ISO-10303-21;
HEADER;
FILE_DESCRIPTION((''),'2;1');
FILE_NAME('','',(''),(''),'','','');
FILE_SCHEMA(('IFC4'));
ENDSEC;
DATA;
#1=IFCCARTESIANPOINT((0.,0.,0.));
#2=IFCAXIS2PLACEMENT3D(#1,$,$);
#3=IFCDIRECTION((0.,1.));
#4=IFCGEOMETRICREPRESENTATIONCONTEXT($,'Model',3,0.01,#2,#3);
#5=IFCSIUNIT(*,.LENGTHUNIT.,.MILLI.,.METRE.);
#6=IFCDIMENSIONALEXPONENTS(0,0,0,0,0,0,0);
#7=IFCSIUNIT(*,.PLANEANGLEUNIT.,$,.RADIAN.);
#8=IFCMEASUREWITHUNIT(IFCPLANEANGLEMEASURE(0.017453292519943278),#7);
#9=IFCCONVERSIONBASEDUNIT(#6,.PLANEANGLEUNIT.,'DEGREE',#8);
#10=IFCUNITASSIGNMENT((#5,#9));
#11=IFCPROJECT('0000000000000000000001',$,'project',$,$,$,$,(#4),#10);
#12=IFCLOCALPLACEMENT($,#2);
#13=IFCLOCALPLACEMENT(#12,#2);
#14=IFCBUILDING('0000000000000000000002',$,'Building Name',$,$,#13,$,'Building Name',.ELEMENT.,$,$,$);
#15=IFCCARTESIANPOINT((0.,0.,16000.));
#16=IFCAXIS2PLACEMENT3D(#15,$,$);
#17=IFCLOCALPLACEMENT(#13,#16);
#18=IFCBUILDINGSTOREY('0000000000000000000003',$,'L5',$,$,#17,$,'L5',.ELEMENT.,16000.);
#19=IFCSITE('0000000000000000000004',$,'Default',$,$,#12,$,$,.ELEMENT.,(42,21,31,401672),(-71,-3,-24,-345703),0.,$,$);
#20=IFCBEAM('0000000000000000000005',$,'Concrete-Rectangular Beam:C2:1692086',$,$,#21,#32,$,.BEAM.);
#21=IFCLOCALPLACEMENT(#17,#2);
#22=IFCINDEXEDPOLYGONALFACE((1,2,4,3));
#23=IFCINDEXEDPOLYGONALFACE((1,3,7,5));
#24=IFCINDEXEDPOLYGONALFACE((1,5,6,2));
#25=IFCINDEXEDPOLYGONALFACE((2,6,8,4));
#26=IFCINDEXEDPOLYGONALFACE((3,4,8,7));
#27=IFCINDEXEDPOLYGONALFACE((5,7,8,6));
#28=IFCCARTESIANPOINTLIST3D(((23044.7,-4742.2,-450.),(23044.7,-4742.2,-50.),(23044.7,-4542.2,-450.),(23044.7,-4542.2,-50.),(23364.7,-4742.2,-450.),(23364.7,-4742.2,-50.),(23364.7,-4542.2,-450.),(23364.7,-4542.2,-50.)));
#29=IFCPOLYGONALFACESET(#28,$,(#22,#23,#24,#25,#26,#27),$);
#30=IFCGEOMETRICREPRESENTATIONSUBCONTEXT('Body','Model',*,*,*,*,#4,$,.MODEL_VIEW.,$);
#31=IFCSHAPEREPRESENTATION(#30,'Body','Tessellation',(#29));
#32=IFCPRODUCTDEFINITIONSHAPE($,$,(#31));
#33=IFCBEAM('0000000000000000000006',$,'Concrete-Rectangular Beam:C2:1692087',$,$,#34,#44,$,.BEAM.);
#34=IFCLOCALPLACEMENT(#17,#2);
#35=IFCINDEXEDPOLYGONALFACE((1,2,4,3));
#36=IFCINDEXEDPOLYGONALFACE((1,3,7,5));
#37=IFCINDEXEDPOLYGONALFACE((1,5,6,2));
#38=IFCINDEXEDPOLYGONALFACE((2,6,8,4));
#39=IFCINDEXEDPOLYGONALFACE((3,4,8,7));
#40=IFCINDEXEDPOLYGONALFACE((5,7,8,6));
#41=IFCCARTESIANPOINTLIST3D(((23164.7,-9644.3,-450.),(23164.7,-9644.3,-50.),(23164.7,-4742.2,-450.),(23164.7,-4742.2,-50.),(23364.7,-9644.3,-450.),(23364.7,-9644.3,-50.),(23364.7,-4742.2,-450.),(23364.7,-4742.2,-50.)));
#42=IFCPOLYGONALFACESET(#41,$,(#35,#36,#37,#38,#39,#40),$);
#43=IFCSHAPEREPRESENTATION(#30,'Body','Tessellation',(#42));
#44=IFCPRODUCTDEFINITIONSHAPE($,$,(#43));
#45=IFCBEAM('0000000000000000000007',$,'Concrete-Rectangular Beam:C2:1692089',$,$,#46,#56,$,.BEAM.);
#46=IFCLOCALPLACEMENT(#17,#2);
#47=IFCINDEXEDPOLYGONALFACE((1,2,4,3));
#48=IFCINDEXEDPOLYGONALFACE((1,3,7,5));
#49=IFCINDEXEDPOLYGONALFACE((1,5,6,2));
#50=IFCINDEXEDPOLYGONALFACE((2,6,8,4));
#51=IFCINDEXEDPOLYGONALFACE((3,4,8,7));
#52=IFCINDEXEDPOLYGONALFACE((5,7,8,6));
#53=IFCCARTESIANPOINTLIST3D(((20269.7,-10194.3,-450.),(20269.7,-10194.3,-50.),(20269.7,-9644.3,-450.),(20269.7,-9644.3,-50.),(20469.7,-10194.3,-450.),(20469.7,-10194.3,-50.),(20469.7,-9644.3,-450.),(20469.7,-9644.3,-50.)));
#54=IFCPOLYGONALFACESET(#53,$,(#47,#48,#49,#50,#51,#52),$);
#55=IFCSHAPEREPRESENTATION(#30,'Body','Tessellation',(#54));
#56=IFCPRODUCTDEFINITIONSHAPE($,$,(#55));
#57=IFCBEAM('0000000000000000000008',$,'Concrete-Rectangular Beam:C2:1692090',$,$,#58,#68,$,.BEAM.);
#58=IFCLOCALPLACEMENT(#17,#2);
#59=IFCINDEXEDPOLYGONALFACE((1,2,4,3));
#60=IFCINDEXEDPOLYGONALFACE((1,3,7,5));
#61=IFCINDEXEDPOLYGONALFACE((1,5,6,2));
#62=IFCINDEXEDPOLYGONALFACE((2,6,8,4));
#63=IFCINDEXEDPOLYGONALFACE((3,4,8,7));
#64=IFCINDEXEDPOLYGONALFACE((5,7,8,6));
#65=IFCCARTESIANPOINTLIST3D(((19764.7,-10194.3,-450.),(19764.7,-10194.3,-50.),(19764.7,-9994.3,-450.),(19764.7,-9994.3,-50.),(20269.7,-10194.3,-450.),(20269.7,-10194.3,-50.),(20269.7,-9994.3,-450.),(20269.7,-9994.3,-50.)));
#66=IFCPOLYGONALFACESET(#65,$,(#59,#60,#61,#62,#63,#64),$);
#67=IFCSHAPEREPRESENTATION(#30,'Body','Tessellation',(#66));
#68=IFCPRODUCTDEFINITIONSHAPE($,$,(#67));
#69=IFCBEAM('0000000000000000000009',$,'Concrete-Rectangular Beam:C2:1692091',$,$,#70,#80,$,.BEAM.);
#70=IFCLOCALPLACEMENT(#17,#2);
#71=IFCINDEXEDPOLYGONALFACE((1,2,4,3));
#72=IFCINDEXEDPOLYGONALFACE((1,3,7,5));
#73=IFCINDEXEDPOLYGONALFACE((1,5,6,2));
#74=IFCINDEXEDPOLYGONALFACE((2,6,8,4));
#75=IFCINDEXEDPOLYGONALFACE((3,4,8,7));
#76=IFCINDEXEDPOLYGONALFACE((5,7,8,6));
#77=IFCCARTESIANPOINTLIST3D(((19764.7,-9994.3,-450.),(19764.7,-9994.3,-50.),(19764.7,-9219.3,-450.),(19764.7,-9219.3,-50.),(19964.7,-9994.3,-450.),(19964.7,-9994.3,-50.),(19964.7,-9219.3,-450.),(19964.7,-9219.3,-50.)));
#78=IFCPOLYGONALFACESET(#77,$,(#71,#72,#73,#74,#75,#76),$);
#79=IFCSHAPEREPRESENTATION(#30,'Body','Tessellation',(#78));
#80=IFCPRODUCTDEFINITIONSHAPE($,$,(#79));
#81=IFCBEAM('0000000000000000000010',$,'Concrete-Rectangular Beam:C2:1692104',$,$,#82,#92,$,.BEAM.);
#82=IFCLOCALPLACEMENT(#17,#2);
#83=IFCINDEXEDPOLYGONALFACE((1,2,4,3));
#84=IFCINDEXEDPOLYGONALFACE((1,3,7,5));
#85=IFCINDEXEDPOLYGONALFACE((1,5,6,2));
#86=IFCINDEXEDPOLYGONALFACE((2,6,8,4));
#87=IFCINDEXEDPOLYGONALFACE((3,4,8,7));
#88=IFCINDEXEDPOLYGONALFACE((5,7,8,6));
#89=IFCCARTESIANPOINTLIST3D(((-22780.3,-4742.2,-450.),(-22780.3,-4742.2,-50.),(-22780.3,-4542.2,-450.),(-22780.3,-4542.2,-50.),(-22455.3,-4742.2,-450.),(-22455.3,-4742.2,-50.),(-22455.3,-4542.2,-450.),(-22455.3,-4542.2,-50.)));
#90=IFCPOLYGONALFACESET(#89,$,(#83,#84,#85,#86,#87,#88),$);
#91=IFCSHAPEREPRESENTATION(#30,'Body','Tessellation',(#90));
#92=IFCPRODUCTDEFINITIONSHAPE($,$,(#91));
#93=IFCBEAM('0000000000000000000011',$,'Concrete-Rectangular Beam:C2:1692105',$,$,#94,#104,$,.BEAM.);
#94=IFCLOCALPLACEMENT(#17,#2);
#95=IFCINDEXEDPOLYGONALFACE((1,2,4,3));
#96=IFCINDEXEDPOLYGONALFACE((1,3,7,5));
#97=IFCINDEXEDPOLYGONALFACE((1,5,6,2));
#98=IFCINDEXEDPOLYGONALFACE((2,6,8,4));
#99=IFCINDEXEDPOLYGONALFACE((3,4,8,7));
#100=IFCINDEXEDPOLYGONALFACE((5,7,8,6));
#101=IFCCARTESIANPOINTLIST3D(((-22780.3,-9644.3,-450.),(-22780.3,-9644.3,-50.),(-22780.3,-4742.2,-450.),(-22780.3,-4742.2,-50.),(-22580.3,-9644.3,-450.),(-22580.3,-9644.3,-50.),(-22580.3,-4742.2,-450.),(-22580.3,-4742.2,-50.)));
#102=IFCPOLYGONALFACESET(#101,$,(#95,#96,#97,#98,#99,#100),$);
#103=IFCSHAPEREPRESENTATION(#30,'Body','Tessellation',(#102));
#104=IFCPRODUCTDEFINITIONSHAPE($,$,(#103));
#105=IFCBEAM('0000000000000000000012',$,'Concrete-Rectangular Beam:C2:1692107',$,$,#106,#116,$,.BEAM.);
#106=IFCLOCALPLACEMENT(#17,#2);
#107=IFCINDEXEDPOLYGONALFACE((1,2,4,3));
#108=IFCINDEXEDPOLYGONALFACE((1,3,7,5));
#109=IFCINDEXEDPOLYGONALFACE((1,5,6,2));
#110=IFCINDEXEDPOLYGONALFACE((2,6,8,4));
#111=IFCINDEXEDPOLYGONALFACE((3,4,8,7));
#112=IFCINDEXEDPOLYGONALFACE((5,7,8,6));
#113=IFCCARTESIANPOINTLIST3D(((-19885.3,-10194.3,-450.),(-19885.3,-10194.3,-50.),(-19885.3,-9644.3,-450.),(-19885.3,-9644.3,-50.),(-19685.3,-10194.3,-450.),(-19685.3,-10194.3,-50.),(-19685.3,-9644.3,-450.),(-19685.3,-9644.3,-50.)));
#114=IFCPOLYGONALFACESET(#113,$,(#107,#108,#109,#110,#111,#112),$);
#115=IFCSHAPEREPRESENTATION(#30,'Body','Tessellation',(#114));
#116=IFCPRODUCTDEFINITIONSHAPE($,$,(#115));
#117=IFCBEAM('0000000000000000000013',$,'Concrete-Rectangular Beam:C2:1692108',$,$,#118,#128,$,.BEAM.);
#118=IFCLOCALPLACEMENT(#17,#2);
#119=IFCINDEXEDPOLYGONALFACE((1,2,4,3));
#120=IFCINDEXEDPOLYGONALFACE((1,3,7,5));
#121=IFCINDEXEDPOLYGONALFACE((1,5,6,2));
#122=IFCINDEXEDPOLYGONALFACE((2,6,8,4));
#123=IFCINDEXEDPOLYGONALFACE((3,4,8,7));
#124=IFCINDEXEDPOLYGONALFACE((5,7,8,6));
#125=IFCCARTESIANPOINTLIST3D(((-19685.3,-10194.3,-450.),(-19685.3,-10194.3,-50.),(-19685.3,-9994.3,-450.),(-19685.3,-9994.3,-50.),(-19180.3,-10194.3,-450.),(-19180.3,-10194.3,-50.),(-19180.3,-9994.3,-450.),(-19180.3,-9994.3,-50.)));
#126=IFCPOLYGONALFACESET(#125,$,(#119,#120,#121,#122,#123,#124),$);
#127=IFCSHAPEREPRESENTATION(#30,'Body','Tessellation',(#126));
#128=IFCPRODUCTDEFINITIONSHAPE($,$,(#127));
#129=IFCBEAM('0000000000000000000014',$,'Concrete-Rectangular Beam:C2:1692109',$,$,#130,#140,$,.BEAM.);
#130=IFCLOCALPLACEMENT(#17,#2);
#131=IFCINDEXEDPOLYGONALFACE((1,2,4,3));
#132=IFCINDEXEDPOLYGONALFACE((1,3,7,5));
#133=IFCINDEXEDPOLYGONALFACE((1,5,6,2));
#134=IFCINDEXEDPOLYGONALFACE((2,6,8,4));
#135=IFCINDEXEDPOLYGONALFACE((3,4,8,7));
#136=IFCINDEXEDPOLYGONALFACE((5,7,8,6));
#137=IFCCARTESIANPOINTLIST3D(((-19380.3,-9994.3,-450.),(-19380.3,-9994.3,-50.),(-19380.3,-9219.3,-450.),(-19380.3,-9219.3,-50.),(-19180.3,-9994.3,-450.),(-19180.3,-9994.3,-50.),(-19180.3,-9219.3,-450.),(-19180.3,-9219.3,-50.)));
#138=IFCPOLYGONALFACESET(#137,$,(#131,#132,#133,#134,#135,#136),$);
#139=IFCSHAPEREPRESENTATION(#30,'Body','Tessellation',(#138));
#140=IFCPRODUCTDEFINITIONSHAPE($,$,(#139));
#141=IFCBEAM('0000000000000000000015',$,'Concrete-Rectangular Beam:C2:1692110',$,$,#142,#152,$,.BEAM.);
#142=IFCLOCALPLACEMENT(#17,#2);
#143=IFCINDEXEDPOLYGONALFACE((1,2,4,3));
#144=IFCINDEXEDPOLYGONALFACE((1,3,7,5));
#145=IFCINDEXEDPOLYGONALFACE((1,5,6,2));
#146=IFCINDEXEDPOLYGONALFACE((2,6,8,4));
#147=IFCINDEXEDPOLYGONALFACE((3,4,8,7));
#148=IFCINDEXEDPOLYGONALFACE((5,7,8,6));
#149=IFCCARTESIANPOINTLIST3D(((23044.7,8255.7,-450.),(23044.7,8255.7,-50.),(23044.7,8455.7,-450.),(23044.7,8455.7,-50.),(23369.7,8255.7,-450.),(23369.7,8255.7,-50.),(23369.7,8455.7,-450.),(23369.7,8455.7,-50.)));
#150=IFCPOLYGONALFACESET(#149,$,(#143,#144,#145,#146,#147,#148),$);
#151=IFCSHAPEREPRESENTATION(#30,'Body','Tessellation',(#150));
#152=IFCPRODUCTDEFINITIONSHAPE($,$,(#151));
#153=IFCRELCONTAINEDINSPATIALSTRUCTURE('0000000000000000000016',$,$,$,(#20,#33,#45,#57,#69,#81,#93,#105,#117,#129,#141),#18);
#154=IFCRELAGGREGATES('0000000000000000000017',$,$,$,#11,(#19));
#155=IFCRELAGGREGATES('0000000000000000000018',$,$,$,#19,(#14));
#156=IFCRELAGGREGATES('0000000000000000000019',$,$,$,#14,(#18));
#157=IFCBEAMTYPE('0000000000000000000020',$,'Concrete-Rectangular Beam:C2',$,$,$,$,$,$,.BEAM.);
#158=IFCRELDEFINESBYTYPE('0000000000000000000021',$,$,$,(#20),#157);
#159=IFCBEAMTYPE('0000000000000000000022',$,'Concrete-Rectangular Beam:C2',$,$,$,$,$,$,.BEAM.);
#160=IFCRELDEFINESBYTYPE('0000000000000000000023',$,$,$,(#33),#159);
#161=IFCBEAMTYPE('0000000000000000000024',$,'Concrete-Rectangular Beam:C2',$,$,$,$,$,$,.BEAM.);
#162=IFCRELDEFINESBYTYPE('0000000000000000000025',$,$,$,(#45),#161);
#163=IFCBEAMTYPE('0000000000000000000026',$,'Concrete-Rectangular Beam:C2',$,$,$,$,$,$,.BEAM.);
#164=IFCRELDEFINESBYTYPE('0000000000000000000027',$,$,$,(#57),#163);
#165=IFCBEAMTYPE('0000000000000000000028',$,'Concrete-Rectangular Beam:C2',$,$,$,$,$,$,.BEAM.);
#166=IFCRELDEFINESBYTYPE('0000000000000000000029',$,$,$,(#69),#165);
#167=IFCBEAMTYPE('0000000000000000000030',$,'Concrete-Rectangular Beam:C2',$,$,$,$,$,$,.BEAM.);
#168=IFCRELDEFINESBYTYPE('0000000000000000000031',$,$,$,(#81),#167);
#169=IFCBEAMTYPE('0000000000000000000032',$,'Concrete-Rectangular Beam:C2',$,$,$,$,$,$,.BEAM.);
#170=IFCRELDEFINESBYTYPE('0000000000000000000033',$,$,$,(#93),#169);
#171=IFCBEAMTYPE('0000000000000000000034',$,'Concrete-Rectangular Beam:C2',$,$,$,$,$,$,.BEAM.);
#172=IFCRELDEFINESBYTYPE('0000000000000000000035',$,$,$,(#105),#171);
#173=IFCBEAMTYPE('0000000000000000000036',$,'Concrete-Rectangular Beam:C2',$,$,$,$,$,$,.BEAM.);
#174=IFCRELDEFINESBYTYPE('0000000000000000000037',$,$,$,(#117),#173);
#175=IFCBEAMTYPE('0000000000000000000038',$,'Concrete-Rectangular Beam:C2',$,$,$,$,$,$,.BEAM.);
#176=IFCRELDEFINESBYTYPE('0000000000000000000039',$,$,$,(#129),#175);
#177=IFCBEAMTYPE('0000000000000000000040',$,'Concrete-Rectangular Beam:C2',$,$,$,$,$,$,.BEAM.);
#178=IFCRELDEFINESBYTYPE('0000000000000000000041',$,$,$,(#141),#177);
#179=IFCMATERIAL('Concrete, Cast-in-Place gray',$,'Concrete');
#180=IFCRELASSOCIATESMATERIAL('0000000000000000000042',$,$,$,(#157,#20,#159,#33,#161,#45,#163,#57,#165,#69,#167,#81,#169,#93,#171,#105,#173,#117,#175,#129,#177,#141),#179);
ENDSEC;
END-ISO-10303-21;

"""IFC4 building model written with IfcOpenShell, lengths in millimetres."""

from ifc_helpers import new_model, entity, si_unit, converted_unit, direction, frame, origin, place, context, subcontext, project, spatial, indexed_curve, outline, extrude, source, transform, mapped, material, type_object, type_shapes, element, save


model = new_model("IFC4")

# Units and contexts
model_context = context("Model", 3, precision=0.01, world=origin(), true_north=direction((0.0, 1.0)))
body_context = subcontext(model_context, "Body", "Model", "MODEL_VIEW")
ifc_project = project(units=[si_unit("LENGTHUNIT", "METRE", prefix="MILLI"), converted_unit("PLANEANGLEUNIT", "DEGREE", entity("IfcPlaneAngleMeasure", 0.017453292519943278), si_unit("PLANEANGLEUNIT", "RADIAN"), dimensions=[0, 0, 0, 0, 0, 0, 0])], contexts=[model_context])

# Site, building, storey
site_placement = place(None, origin())
site = spatial("IfcSite", under=ifc_project, at=site_placement, Name="Default", CompositionType="ELEMENT", RefLatitude=(42, 21, 31, 401672), RefLongitude=(-71, -3, -24, -345703), RefElevation=0.0)
building_placement = place(site_placement, origin())
building = spatial("IfcBuilding", under=site, at=building_placement, Name="Building Name", LongName="Building Name", CompositionType="ELEMENT")
storey_placement = place(building_placement, frame((0.0, 0.0, 16000.0)))
storey = spatial("IfcBuildingStorey", under=building, at=storey_placement, Name="L5", LongName="L5", CompositionType="ELEMENT", Elevation=16000.0)

# Beams
ifc_material = material(Name="Concrete, Cast-in-Place gray", Category="Concrete")
beam_type_1 = type_object("IfcBeamType", Name="Concrete-Rectangular Beam:C2", PredefinedType="BEAM", material=ifc_material)
shared_shape_1 = source(origin(), body_context, "Body", "SweptSolid", [
    extrude(outline(indexed_curve([(-200.0, -100.0), (200.0, -100.0), (200.0, 100.0), (-200.0, 100.0), (-200.0, -100.0)], self_intersect=False)), frame((23044.7, -4642.2, 15750.0), z_axis=(1.0, 0.0, 0.0), x_axis=(0.0, 0.0, -1.0)), (0.0, 0.0, 1.0), 320.0),
])
type_shapes(beam_type_1, [shared_shape_1])
beam_1_placement = place(storey_placement, frame((0.0, 0.0, -16000.0)))
element("IfcBeam", 1, at=beam_1_placement, inside=storey, type_object=beam_type_1, material=ifc_material, Name="Concrete-Rectangular Beam:C2:1692086", PredefinedType="BEAM", context=body_context, shape_type="MappedRepresentation", body=[
    mapped(shared_shape_1, transform((0.0, 0.0, 0.0), scale=1.0)),
])
beam_type_2 = type_object("IfcBeamType", Name="Concrete-Rectangular Beam:C2", PredefinedType="BEAM", material=ifc_material)
shared_shape_2 = source(origin(), body_context, "Body", "SweptSolid", [
    extrude(outline(indexed_curve([(-100.0, -200.0), (100.0, -200.0), (100.0, 200.0), (-100.0, 200.0), (-100.0, -200.0)], self_intersect=False)), frame((23264.7, -4742.2, 15750.0), z_axis=(0.0, -1.0, 0.0), x_axis=(-1.0, 0.0, 0.0)), (0.0, 0.0, 1.0), 4902.1),
])
type_shapes(beam_type_2, [shared_shape_2])
beam_2_placement = place(storey_placement, frame((0.0, 0.0, -16000.0)))
element("IfcBeam", 2, at=beam_2_placement, inside=storey, type_object=beam_type_2, material=ifc_material, Name="Concrete-Rectangular Beam:C2:1692087", PredefinedType="BEAM", context=body_context, shape_type="MappedRepresentation", body=[
    mapped(shared_shape_2, transform((0.0, 0.0, 0.0), scale=1.0)),
])
beam_type_3 = type_object("IfcBeamType", Name="Concrete-Rectangular Beam:C2", PredefinedType="BEAM", material=ifc_material)
shared_shape_3 = source(origin(), body_context, "Body", "SweptSolid", [
    extrude(outline(indexed_curve([(-100.0, -200.0), (100.0, -200.0), (100.0, 200.0), (-100.0, 200.0), (-100.0, -200.0)], self_intersect=False)), frame((20369.7, -9644.3, 15750.0), z_axis=(0.0, -1.0, 0.0), x_axis=(-1.0, 0.0, 0.0)), (0.0, 0.0, 1.0), 550.0),
])
type_shapes(beam_type_3, [shared_shape_3])
beam_3_placement = place(storey_placement, frame((0.0, 0.0, -16000.0)))
element("IfcBeam", 3, at=beam_3_placement, inside=storey, type_object=beam_type_3, material=ifc_material, Name="Concrete-Rectangular Beam:C2:1692089", PredefinedType="BEAM", context=body_context, shape_type="MappedRepresentation", body=[
    mapped(shared_shape_3, transform((0.0, 0.0, 0.0), scale=1.0)),
])
beam_type_4 = type_object("IfcBeamType", Name="Concrete-Rectangular Beam:C2", PredefinedType="BEAM", material=ifc_material)
shared_shape_4 = source(origin(), body_context, "Body", "SweptSolid", [
    extrude(outline(indexed_curve([(-200.0, -100.0), (200.0, -100.0), (200.0, 100.0), (-200.0, 100.0), (-200.0, -100.0)], self_intersect=False)), frame((20269.7, -10094.3, 15750.0), z_axis=(-1.0, 0.0, 0.0), x_axis=(0.0, 0.0, -1.0)), (0.0, 0.0, 1.0), 505.0),
])
type_shapes(beam_type_4, [shared_shape_4])
beam_4_placement = place(storey_placement, frame((0.0, 0.0, -16000.0)))
element("IfcBeam", 4, at=beam_4_placement, inside=storey, type_object=beam_type_4, material=ifc_material, Name="Concrete-Rectangular Beam:C2:1692090", PredefinedType="BEAM", context=body_context, shape_type="MappedRepresentation", body=[
    mapped(shared_shape_4, transform((0.0, 0.0, 0.0), scale=1.0)),
])
beam_type_5 = type_object("IfcBeamType", Name="Concrete-Rectangular Beam:C2", PredefinedType="BEAM", material=ifc_material)
shared_shape_5 = source(origin(), body_context, "Body", "SweptSolid", [
    extrude(outline(indexed_curve([(-100.0, -200.0), (100.0, -200.0), (100.0, 200.0), (-100.0, 200.0), (-100.0, -200.0)], self_intersect=False)), frame((19864.7, -9994.3, 15750.0), z_axis=(0.0, 1.0, 0.0), x_axis=(-1.0, 0.0, 0.0)), (0.0, 0.0, 1.0), 775.0),
])
type_shapes(beam_type_5, [shared_shape_5])
beam_5_placement = place(storey_placement, frame((0.0, 0.0, -16000.0)))
element("IfcBeam", 5, at=beam_5_placement, inside=storey, type_object=beam_type_5, material=ifc_material, Name="Concrete-Rectangular Beam:C2:1692091", PredefinedType="BEAM", context=body_context, shape_type="MappedRepresentation", body=[
    mapped(shared_shape_5, transform((0.0, 0.0, 0.0), scale=1.0)),
])
beam_type_6 = type_object("IfcBeamType", Name="Concrete-Rectangular Beam:C2", PredefinedType="BEAM", material=ifc_material)
shared_shape_6 = source(origin(), body_context, "Body", "SweptSolid", [
    extrude(outline(indexed_curve([(-200.0, -100.0), (200.0, -100.0), (200.0, 100.0), (-200.0, 100.0), (-200.0, -100.0)], self_intersect=False)), frame((-22455.3, -4642.2, 15750.0), z_axis=(-1.0, 0.0, 0.0), x_axis=(0.0, 0.0, -1.0)), (0.0, 0.0, 1.0), 325.0),
])
type_shapes(beam_type_6, [shared_shape_6])
beam_6_placement = place(storey_placement, frame((0.0, 0.0, -16000.0)))
element("IfcBeam", 6, at=beam_6_placement, inside=storey, type_object=beam_type_6, material=ifc_material, Name="Concrete-Rectangular Beam:C2:1692104", PredefinedType="BEAM", context=body_context, shape_type="MappedRepresentation", body=[
    mapped(shared_shape_6, transform((0.0, 0.0, 0.0), scale=1.0)),
])
beam_type_7 = type_object("IfcBeamType", Name="Concrete-Rectangular Beam:C2", PredefinedType="BEAM", material=ifc_material)
shared_shape_7 = source(origin(), body_context, "Body", "SweptSolid", [
    extrude(outline(indexed_curve([(-100.0, -200.0), (100.0, -200.0), (100.0, 200.0), (-100.0, 200.0), (-100.0, -200.0)], self_intersect=False)), frame((-22680.3, -4742.2, 15750.0), z_axis=(0.0, -1.0, 0.0), x_axis=(-1.0, 0.0, 0.0)), (0.0, 0.0, 1.0), 4902.1),
])
type_shapes(beam_type_7, [shared_shape_7])
beam_7_placement = place(storey_placement, frame((0.0, 0.0, -16000.0)))
element("IfcBeam", 7, at=beam_7_placement, inside=storey, type_object=beam_type_7, material=ifc_material, Name="Concrete-Rectangular Beam:C2:1692105", PredefinedType="BEAM", context=body_context, shape_type="MappedRepresentation", body=[
    mapped(shared_shape_7, transform((0.0, 0.0, 0.0), scale=1.0)),
])
beam_type_8 = type_object("IfcBeamType", Name="Concrete-Rectangular Beam:C2", PredefinedType="BEAM", material=ifc_material)
shared_shape_8 = source(origin(), body_context, "Body", "SweptSolid", [
    extrude(outline(indexed_curve([(-100.0, -200.0), (100.0, -200.0), (100.0, 200.0), (-100.0, 200.0), (-100.0, -200.0)], self_intersect=False)), frame((-19785.3, -9644.3, 15750.0), z_axis=(0.0, -1.0, 0.0), x_axis=(-1.0, 0.0, 0.0)), (0.0, 0.0, 1.0), 550.0),
])
type_shapes(beam_type_8, [shared_shape_8])
beam_8_placement = place(storey_placement, frame((0.0, 0.0, -16000.0)))
element("IfcBeam", 8, at=beam_8_placement, inside=storey, type_object=beam_type_8, material=ifc_material, Name="Concrete-Rectangular Beam:C2:1692107", PredefinedType="BEAM", context=body_context, shape_type="MappedRepresentation", body=[
    mapped(shared_shape_8, transform((0.0, 0.0, 0.0), scale=1.0)),
])
beam_type_9 = type_object("IfcBeamType", Name="Concrete-Rectangular Beam:C2", PredefinedType="BEAM", material=ifc_material)
shared_shape_9 = source(origin(), body_context, "Body", "SweptSolid", [
    extrude(outline(indexed_curve([(-200.0, -100.0), (200.0, -100.0), (200.0, 100.0), (-200.0, 100.0), (-200.0, -100.0)], self_intersect=False)), frame((-19685.3, -10094.3, 15750.0), z_axis=(1.0, 0.0, 0.0), x_axis=(0.0, 0.0, -1.0)), (0.0, 0.0, 1.0), 505.0),
])
type_shapes(beam_type_9, [shared_shape_9])
beam_9_placement = place(storey_placement, frame((0.0, 0.0, -16000.0)))
element("IfcBeam", 9, at=beam_9_placement, inside=storey, type_object=beam_type_9, material=ifc_material, Name="Concrete-Rectangular Beam:C2:1692108", PredefinedType="BEAM", context=body_context, shape_type="MappedRepresentation", body=[
    mapped(shared_shape_9, transform((0.0, 0.0, 0.0), scale=1.0)),
])
beam_type_10 = type_object("IfcBeamType", Name="Concrete-Rectangular Beam:C2", PredefinedType="BEAM", material=ifc_material)
shared_shape_10 = source(origin(), body_context, "Body", "SweptSolid", [
    extrude(outline(indexed_curve([(-100.0, -200.0), (100.0, -200.0), (100.0, 200.0), (-100.0, 200.0), (-100.0, -200.0)], self_intersect=False)), frame((-19280.3, -9994.3, 15750.0), z_axis=(0.0, 1.0, 0.0), x_axis=(-1.0, 0.0, 0.0)), (0.0, 0.0, 1.0), 775.0),
])
type_shapes(beam_type_10, [shared_shape_10])
beam_10_placement = place(storey_placement, frame((0.0, 0.0, -16000.0)))
element("IfcBeam", 10, at=beam_10_placement, inside=storey, type_object=beam_type_10, material=ifc_material, Name="Concrete-Rectangular Beam:C2:1692109", PredefinedType="BEAM", context=body_context, shape_type="MappedRepresentation", body=[
    mapped(shared_shape_10, transform((0.0, 0.0, 0.0), scale=1.0)),
])
beam_type_11 = type_object("IfcBeamType", Name="Concrete-Rectangular Beam:C2", PredefinedType="BEAM", material=ifc_material)
shared_shape_11 = source(origin(), body_context, "Body", "SweptSolid", [
    extrude(outline(indexed_curve([(-200.0, -100.0), (200.0, -100.0), (200.0, 100.0), (-200.0, 100.0), (-200.0, -100.0)], self_intersect=False)), frame((23044.7, 8355.7, 15750.0), z_axis=(1.0, 0.0, 0.0), x_axis=(0.0, 0.0, -1.0)), (0.0, 0.0, 1.0), 325.0),
])
type_shapes(beam_type_11, [shared_shape_11])
beam_11_placement = place(storey_placement, frame((0.0, 0.0, -16000.0)))
element("IfcBeam", 11, at=beam_11_placement, inside=storey, type_object=beam_type_11, material=ifc_material, Name="Concrete-Rectangular Beam:C2:1692110", PredefinedType="BEAM", context=body_context, shape_type="MappedRepresentation", body=[
    mapped(shared_shape_11, transform((0.0, 0.0, 0.0), scale=1.0)),
])

save(model, "model.ifc")
